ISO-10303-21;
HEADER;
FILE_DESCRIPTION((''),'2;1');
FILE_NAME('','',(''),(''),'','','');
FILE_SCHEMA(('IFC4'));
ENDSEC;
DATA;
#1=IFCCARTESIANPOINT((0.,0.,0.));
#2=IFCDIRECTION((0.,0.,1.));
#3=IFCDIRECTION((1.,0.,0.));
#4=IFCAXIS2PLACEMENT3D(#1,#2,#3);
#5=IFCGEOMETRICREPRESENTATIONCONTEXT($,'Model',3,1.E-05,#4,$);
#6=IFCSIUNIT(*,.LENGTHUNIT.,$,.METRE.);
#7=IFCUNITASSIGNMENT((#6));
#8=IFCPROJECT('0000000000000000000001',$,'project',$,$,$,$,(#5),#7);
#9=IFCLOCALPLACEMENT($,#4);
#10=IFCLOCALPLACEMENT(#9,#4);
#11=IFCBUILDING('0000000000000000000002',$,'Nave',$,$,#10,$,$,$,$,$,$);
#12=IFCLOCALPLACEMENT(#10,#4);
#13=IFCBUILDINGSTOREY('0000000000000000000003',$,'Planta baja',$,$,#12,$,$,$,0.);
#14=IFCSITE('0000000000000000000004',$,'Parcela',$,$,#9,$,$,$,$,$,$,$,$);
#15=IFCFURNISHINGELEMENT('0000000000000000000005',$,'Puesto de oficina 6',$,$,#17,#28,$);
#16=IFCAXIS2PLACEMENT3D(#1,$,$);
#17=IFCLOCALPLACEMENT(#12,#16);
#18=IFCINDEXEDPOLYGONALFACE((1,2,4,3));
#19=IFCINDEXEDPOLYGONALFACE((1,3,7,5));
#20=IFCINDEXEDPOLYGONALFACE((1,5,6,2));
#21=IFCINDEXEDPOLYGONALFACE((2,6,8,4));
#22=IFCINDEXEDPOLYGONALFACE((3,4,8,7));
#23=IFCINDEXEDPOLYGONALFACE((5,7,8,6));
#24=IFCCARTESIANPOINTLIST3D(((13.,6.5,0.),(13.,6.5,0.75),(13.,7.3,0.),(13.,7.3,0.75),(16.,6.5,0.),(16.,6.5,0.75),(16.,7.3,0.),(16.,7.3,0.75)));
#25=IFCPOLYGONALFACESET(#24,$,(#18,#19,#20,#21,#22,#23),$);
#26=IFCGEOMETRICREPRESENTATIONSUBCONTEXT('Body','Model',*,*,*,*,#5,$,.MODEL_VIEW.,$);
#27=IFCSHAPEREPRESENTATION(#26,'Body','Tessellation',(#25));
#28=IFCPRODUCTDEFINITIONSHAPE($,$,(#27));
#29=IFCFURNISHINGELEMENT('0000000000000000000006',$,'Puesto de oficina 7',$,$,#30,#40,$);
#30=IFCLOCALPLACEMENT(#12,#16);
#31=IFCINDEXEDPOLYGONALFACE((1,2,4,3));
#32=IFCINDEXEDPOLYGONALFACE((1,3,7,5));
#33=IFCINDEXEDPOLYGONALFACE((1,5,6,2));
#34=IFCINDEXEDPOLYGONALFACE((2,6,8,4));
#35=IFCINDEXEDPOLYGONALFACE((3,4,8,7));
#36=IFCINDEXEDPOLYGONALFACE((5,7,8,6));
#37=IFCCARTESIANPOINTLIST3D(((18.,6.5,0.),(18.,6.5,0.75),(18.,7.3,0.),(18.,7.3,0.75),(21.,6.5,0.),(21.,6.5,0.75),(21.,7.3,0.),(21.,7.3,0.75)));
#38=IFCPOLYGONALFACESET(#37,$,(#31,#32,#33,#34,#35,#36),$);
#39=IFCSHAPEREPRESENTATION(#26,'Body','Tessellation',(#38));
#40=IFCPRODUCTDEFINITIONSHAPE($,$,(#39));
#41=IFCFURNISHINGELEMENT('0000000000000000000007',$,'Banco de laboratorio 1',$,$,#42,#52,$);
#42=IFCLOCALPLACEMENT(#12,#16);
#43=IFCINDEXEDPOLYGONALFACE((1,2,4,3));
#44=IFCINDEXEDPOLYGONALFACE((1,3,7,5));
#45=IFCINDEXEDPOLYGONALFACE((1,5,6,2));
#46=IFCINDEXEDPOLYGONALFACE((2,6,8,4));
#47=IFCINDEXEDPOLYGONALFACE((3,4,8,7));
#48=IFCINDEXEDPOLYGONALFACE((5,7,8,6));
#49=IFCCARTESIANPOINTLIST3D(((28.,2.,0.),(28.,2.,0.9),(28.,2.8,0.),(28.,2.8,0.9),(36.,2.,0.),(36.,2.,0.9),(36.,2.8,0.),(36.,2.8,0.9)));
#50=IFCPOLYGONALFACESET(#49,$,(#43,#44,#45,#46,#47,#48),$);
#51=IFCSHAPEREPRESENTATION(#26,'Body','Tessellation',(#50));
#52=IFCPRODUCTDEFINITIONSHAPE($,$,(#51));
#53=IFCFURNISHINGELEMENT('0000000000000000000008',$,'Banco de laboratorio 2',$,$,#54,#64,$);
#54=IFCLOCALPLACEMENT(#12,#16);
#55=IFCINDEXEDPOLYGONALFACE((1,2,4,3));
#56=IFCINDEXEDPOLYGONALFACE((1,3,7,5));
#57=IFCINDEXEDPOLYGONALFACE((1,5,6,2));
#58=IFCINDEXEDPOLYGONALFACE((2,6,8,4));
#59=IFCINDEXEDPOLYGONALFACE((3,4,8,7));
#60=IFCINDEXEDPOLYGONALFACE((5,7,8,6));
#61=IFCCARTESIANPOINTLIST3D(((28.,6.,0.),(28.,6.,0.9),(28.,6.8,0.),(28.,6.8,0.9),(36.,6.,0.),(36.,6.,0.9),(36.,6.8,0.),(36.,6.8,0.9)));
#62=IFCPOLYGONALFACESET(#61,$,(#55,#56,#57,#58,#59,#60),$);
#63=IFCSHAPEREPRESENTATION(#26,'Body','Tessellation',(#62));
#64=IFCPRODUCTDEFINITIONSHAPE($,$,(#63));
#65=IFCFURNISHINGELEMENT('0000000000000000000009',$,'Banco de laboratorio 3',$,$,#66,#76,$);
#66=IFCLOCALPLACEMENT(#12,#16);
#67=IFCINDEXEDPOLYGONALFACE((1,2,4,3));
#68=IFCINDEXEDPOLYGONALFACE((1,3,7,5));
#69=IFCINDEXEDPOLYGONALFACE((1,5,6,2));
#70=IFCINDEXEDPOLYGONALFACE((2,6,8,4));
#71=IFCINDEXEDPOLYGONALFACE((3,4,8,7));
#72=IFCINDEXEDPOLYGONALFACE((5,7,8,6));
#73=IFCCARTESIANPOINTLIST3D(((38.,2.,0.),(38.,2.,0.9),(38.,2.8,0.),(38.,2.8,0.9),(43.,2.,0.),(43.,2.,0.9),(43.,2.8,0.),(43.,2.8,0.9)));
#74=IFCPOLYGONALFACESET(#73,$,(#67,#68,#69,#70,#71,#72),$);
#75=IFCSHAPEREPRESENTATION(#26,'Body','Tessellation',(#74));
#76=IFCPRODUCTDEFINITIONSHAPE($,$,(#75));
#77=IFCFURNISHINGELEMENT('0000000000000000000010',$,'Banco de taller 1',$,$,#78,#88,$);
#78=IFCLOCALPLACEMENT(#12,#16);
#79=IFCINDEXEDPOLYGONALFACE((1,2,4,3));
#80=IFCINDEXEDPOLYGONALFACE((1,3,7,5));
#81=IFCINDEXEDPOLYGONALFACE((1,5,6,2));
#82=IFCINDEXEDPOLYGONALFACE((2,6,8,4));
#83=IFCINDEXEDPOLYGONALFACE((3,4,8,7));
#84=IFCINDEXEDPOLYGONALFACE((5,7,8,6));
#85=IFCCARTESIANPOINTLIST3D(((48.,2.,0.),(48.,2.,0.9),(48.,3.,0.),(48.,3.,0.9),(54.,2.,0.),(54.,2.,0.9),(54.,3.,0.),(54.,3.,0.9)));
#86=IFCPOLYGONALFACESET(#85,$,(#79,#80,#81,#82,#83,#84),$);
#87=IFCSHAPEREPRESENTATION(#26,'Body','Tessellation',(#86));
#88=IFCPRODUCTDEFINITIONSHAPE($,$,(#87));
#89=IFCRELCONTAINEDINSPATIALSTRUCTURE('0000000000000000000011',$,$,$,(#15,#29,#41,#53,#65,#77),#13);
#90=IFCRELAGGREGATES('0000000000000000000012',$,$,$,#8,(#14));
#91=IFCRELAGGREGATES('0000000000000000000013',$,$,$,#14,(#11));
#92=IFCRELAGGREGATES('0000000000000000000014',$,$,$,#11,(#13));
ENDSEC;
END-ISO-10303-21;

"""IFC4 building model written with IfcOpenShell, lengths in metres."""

from ifc_helpers import new_model, si_unit, frame, origin_with_axes, place, context, subcontext, project, spatial, indexed_curve, outline, extrude, element, save


model = new_model("IFC4")

# Units and contexts
model_context = context("Model", 3, precision=1e-05, world=origin_with_axes())
body_context = subcontext(model_context, "Body", "Model", "MODEL_VIEW")
ifc_project = project(units=[si_unit("LENGTHUNIT", "METRE")], contexts=[model_context])

# Site, building, storey
site_placement = place(None, origin_with_axes())
site = spatial("IfcSite", under=ifc_project, at=site_placement, Name="Parcela")
building_placement = place(site_placement, origin_with_axes())
building = spatial("IfcBuilding", under=site, at=building_placement, Name="Nave")
storey_placement = place(building_placement, origin_with_axes())
storey = spatial("IfcBuildingStorey", under=building, at=storey_placement, Name="Planta baja", Elevation=0.0)

# Furnishing elements
for number, where, z_axis, x_axis, name in (
    (1, (13.0, 6.5, 0.0), (0.0, 0.0, 1.0), (1.0, 0.0, 0.0), "Puesto de oficina 6"),
    (2, (18.0, 6.5, 0.0), (0.0, 0.0, 1.0), (1.0, 0.0, 0.0), "Puesto de oficina 7"),
):
    element("IfcFurnishingElement", number, at=place(storey_placement, frame(where, z_axis=z_axis, x_axis=x_axis)), inside=storey, Name=name, context=body_context, shape_type="SweptSolid", body=[
        extrude(outline(indexed_curve([(0.0, 0.0), (0.0, 0.8), (3.0, 0.8), (3.0, 0.0), (0.0, 0.0)], self_intersect=False)), origin_with_axes(), (0.0, 0.0, 1.0), 0.75),
    ])
for number, where, z_axis, x_axis, name in (
    (3, (28.0, 2.0, 0.0), (0.0, 0.0, 1.0), (1.0, 0.0, 0.0), "Banco de laboratorio 1"),
    (4, (28.0, 6.0, 0.0), (0.0, 0.0, 1.0), (1.0, 0.0, 0.0), "Banco de laboratorio 2"),
):
    element("IfcFurnishingElement", number, at=place(storey_placement, frame(where, z_axis=z_axis, x_axis=x_axis)), inside=storey, Name=name, context=body_context, shape_type="SweptSolid", body=[
        extrude(outline(indexed_curve([(0.0, 0.0), (0.0, 0.8), (8.0, 0.8), (8.0, 0.0), (0.0, 0.0)], self_intersect=False)), origin_with_axes(), (0.0, 0.0, 1.0), 0.9),
    ])
furnishing_1_placement = place(storey_placement, frame((38.0, 2.0, 0.0), z_axis=(0.0, 0.0, 1.0), x_axis=(1.0, 0.0, 0.0)))
element("IfcFurnishingElement", 5, at=furnishing_1_placement, inside=storey, Name="Banco de laboratorio 3", context=body_context, shape_type="SweptSolid", body=[
    extrude(outline(indexed_curve([(0.0, 0.0), (0.0, 0.8), (5.0, 0.8), (5.0, 0.0), (0.0, 0.0)], self_intersect=False)), origin_with_axes(), (0.0, 0.0, 1.0), 0.9),
])
furnishing_2_placement = place(storey_placement, frame((48.0, 2.0, 0.0), z_axis=(0.0, 0.0, 1.0), x_axis=(1.0, 0.0, 0.0)))
element("IfcFurnishingElement", 6, at=furnishing_2_placement, inside=storey, Name="Banco de taller 1", context=body_context, shape_type="SweptSolid", body=[
    extrude(outline(indexed_curve([(0.0, 0.0), (0.0, 1.0), (6.0, 1.0), (6.0, 0.0), (0.0, 0.0)], self_intersect=False)), origin_with_axes(), (0.0, 0.0, 1.0), 0.9),
])

save(model, "model.ifc")
